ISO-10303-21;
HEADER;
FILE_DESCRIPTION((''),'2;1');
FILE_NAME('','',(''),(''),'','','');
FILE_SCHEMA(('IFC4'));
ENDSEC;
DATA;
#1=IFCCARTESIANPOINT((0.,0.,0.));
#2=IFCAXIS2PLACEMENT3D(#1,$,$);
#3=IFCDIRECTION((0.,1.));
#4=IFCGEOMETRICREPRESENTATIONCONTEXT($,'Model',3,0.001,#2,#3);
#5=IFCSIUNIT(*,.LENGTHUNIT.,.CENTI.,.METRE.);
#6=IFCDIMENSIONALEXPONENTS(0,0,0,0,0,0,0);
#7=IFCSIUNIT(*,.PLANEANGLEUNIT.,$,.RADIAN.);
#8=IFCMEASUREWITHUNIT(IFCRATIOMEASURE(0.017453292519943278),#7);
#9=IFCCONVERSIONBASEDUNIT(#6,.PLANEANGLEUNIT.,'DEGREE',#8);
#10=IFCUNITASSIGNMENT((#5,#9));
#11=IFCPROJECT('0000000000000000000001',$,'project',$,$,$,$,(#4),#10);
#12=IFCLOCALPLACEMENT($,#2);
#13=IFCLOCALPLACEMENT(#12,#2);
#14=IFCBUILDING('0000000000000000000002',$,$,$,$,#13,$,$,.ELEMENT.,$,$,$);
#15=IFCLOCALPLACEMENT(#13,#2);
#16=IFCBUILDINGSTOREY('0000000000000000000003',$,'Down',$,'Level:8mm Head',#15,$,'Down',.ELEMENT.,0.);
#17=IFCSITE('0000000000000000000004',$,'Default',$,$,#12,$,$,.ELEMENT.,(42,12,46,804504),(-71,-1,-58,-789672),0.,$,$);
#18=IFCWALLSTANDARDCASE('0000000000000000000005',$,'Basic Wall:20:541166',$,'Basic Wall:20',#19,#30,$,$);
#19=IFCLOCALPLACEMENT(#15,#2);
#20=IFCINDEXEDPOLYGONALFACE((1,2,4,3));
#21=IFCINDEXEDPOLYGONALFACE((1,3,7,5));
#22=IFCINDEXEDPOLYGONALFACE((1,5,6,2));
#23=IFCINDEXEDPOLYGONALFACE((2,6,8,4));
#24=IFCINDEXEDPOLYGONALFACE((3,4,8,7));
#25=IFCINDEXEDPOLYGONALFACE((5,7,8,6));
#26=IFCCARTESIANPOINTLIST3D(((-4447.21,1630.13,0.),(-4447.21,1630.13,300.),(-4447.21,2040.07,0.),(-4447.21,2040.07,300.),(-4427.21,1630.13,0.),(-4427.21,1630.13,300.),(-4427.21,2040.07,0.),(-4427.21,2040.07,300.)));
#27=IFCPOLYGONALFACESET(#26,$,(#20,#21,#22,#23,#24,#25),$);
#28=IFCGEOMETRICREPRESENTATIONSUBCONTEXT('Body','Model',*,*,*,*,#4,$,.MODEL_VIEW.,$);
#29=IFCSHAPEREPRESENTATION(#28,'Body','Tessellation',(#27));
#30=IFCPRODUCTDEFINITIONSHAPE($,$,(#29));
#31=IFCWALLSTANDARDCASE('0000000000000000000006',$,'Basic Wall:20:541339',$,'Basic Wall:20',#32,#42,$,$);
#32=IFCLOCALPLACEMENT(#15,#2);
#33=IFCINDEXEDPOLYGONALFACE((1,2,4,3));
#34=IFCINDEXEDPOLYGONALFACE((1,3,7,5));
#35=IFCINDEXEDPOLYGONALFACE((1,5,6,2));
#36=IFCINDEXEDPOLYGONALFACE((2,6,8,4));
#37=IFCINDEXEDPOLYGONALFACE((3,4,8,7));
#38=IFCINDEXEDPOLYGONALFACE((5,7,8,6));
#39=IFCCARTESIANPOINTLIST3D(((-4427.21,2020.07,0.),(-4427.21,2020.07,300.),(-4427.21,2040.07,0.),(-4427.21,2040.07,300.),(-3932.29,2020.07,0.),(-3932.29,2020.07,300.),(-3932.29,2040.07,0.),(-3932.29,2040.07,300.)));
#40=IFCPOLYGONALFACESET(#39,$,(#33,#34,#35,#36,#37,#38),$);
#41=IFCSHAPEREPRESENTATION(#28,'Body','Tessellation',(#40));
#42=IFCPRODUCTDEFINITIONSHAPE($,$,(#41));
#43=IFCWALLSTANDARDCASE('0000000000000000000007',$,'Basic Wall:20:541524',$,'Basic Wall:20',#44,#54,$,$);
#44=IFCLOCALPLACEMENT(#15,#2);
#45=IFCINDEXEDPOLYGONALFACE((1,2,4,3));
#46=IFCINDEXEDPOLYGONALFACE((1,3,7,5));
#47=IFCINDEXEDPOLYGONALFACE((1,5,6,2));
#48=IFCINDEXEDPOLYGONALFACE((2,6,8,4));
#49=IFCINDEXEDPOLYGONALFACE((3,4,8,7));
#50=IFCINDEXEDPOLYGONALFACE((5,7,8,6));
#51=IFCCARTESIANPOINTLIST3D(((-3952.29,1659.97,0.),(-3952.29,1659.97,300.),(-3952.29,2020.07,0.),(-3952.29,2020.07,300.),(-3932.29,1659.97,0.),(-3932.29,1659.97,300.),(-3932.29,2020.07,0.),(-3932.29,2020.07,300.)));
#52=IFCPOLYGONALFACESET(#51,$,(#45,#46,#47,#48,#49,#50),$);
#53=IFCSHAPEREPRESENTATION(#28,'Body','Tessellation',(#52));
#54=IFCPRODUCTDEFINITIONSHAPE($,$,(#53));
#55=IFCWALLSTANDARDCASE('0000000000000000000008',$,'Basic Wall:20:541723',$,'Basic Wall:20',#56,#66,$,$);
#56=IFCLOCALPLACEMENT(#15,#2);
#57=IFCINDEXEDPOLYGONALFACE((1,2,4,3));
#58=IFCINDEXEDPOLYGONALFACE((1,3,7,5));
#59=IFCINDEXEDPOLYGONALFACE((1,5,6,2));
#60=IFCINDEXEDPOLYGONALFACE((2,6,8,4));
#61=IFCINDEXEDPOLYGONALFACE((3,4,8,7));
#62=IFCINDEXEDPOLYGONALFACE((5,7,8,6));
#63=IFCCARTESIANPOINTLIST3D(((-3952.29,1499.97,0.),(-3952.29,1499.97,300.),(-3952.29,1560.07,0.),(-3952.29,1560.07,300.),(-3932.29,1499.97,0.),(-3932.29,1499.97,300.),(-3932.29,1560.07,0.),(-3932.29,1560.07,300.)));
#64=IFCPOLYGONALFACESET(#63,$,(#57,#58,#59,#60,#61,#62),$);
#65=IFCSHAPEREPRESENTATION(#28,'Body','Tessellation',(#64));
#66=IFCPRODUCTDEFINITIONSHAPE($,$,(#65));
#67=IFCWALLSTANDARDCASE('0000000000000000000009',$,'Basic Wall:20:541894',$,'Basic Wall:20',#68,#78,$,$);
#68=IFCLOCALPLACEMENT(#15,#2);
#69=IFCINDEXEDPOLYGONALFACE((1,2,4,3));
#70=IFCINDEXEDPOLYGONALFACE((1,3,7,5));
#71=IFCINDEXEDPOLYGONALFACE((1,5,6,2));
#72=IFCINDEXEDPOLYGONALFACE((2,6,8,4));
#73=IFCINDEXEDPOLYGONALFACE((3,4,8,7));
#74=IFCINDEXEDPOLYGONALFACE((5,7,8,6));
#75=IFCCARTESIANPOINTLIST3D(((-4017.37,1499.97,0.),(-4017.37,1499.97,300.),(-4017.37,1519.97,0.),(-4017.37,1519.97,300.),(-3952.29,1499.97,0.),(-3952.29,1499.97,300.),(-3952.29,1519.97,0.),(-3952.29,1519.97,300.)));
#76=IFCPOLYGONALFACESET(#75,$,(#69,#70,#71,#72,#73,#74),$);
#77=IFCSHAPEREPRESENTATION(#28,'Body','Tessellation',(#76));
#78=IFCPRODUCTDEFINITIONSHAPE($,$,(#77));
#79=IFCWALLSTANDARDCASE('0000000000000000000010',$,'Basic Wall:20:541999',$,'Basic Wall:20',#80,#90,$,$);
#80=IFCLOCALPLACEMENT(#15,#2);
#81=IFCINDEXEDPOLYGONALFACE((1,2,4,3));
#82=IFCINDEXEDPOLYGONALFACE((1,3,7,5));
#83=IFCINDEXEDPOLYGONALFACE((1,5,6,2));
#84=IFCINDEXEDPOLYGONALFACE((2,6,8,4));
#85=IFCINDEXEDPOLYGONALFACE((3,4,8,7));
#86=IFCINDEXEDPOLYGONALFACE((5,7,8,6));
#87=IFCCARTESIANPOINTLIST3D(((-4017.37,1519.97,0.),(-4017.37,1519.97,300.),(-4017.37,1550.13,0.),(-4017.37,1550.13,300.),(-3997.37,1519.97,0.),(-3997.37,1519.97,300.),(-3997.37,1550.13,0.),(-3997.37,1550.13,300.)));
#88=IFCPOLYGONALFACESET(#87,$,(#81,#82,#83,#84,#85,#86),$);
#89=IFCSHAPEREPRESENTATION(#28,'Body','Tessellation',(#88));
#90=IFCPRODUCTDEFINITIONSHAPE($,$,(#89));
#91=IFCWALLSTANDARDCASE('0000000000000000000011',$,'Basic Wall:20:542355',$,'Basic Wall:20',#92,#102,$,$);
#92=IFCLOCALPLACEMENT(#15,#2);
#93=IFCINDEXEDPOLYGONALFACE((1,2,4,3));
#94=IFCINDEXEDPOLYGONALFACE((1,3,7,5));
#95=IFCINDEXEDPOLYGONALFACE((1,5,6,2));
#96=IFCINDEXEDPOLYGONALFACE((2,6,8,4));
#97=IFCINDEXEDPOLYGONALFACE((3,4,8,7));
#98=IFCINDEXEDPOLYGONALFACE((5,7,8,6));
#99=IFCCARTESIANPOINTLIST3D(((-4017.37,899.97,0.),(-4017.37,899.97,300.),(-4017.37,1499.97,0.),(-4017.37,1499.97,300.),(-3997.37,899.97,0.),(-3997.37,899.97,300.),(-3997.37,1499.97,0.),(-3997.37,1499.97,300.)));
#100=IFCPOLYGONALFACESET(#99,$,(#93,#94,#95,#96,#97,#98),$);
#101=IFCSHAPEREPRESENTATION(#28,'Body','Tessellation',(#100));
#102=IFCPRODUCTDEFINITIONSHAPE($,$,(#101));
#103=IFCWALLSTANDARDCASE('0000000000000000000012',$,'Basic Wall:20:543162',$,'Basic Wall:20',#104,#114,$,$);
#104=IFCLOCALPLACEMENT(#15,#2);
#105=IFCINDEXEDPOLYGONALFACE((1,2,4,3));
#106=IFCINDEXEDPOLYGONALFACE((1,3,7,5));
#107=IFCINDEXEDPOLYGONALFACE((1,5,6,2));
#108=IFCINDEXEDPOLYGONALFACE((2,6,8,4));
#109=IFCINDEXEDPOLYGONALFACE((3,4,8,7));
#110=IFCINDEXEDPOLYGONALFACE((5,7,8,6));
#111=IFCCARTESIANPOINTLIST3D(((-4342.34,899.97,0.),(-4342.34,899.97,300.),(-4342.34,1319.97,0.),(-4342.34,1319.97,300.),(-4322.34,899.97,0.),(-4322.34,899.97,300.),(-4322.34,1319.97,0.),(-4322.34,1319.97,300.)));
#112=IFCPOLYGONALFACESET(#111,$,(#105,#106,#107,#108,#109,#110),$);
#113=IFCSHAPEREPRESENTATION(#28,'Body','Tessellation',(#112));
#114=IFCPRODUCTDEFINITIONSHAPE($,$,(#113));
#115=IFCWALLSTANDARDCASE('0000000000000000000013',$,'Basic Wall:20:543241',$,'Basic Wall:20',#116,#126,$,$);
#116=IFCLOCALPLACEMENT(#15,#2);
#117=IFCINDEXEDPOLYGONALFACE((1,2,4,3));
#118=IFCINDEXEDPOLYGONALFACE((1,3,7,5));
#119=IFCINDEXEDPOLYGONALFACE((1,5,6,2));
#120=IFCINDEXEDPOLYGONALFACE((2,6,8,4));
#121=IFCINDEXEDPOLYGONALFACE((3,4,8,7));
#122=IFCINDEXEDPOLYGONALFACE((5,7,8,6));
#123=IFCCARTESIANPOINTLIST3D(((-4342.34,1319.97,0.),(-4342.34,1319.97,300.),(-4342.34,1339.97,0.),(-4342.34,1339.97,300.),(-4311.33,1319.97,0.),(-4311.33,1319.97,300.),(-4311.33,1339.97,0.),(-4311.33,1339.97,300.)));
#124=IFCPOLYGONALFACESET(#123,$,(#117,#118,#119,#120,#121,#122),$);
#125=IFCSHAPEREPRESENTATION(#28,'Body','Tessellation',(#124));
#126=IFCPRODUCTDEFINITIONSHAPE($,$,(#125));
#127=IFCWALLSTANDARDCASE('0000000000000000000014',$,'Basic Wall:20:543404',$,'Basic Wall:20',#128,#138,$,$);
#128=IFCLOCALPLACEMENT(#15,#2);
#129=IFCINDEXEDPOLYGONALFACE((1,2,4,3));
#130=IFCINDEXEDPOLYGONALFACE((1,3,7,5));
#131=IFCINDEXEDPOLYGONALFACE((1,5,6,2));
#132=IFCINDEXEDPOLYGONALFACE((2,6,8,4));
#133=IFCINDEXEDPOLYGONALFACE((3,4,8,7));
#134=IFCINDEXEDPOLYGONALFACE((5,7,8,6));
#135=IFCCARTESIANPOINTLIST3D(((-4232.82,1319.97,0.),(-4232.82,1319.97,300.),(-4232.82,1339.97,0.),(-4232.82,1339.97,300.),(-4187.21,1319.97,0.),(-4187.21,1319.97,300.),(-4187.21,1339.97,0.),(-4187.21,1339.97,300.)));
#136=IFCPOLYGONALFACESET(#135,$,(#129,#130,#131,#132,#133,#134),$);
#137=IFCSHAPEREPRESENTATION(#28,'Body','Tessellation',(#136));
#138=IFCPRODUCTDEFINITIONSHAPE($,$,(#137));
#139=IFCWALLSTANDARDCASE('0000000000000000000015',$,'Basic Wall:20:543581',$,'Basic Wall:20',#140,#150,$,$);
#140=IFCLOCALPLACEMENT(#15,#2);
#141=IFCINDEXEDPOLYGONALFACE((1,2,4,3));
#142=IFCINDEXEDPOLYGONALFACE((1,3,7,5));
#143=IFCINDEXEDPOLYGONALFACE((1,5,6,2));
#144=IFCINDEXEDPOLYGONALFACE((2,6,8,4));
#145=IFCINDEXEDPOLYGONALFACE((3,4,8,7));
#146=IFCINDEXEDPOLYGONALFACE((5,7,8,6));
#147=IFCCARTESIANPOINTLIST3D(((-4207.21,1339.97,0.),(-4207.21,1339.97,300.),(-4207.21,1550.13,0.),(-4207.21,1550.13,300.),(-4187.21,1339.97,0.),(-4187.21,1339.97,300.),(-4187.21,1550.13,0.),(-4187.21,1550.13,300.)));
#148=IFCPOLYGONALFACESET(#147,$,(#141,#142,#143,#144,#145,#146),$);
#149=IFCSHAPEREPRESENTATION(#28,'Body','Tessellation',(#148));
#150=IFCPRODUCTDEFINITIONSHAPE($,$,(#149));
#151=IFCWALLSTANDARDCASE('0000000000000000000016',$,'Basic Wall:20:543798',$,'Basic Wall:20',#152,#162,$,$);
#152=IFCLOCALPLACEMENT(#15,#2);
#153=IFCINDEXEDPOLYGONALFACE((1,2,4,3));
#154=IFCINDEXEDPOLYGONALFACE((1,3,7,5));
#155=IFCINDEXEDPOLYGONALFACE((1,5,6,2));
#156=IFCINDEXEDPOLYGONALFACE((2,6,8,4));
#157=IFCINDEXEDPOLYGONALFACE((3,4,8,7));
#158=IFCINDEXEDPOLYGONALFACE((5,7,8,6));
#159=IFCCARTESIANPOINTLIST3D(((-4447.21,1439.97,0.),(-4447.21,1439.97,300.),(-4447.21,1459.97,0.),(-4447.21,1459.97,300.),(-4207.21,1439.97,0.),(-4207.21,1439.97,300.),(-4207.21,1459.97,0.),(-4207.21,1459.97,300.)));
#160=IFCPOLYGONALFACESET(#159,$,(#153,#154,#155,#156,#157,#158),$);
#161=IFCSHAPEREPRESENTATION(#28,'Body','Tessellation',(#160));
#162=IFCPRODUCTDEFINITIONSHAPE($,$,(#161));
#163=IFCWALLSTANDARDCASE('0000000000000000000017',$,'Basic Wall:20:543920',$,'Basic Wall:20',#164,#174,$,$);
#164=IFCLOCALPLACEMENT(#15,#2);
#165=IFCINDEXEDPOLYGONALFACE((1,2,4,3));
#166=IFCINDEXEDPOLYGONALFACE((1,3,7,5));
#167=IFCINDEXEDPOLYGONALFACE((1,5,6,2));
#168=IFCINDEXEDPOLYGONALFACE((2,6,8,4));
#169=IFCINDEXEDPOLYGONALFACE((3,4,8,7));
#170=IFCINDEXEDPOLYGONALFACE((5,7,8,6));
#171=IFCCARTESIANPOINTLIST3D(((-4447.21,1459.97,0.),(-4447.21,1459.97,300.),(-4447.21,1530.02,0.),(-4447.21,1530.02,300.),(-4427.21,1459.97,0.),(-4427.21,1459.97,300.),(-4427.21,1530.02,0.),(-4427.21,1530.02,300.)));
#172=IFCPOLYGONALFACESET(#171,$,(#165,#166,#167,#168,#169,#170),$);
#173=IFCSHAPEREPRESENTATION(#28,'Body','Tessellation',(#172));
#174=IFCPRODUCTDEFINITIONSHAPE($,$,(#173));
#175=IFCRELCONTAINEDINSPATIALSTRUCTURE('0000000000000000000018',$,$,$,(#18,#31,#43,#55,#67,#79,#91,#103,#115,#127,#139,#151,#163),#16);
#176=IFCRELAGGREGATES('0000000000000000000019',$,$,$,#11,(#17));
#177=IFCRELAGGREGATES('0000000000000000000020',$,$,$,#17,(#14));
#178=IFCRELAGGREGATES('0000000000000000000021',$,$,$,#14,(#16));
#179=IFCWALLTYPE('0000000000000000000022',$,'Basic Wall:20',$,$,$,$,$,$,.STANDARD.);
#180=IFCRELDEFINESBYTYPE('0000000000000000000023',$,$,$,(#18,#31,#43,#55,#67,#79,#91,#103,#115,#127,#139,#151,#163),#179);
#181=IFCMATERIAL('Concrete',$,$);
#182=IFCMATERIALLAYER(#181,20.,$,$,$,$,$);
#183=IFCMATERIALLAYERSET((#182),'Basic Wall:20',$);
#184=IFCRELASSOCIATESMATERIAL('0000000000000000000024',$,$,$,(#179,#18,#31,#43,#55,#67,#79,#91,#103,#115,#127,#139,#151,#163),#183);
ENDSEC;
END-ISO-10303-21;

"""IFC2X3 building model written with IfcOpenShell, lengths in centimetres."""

from ifc_helpers import new_model, entity, si_unit, converted_unit, direction, frame, frame_2d, origin, place, context, subcontext, project, spatial, rectangle, extrude, material, layer, layer_set, layer_usage, type_object, element, save


model = new_model("IFC2X3")

# Units and contexts
model_context = context("Model", 3, precision=0.001, world=origin(), true_north=direction((0.0, 1.0)))
body_context = subcontext(model_context, "Body", "Model", "MODEL_VIEW")
ifc_project = project(units=[si_unit("LENGTHUNIT", "METRE", prefix="CENTI"), converted_unit("PLANEANGLEUNIT", "DEGREE", entity("IfcRatioMeasure", 0.017453292519943278), si_unit("PLANEANGLEUNIT", "RADIAN"), dimensions=[0, 0, 0, 0, 0, 0, 0])], contexts=[model_context])

# Site, building, storey
site_placement = place(None, origin())
site = spatial("IfcSite", under=ifc_project, at=site_placement, Name="Default", CompositionType="ELEMENT", RefLatitude=(42, 12, 46, 804504), RefLongitude=(-71, -1, -58, -789672), RefElevation=0.0)
building_placement = place(site_placement, origin())
building = spatial("IfcBuilding", under=site, at=building_placement, CompositionType="ELEMENT")
storey_placement = place(building_placement, origin())
storey = spatial("IfcBuildingStorey", under=building, at=storey_placement, Name="Down", ObjectType="Level:8mm Head", LongName="Down", CompositionType="ELEMENT", Elevation=0.0)

# Shared definitions
ifc_material = material(Name="Concrete")

# Walls
ifc_layer_1 = layer(ifc_material, 20.0)
ifc_layer_set_1 = layer_set([ifc_layer_1], Name="Basic Wall:20")
wall_type_1 = type_object("IfcWallType", Name="Basic Wall:20", PredefinedType="STANDARD", material=ifc_layer_set_1)
ifc_layer_usage_1 = layer_usage(ifc_layer_set_1, "AXIS2", "NEGATIVE", 10.0)
wall_1_placement = place(storey_placement, frame((-4437.21, 1630.13, 0.0), z_axis=(0.0, 0.0, 1.0), x_axis=(0.0, 1.0, 0.0)))
element("IfcWallStandardCase", 1, at=wall_1_placement, inside=storey, type_object=wall_type_1, material=ifc_layer_usage_1, Name="Basic Wall:20:541166", ObjectType="Basic Wall:20", context=body_context, shape_type="SweptSolid", body=[
    extrude(rectangle(XDim=409.95, YDim=20.0, at=frame_2d((204.97, 0.0), x_axis=(-1.0, 0.0))), origin(), (0.0, 0.0, 1.0), 300.0),
])
ifc_layer_usage_2 = layer_usage(ifc_layer_set_1, "AXIS2", "NEGATIVE", 10.0)
wall_2_placement = place(storey_placement, frame((-4427.21, 2030.07, 0.0)))
element("IfcWallStandardCase", 2, at=wall_2_placement, inside=storey, type_object=wall_type_1, material=ifc_layer_usage_2, Name="Basic Wall:20:541339", ObjectType="Basic Wall:20", context=body_context, shape_type="SweptSolid", body=[
    extrude(rectangle(XDim=494.92, YDim=20.0, at=frame_2d((247.46, 0.0), x_axis=(-1.0, 0.0))), origin(), (0.0, 0.0, 1.0), 300.0),
])
ifc_layer_usage_3 = layer_usage(ifc_layer_set_1, "AXIS2", "NEGATIVE", 10.0)
wall_3_placement = place(storey_placement, frame((-3942.29, 2020.07, 0.0), z_axis=(0.0, 0.0, 1.0), x_axis=(0.0, -1.0, 0.0)))
element("IfcWallStandardCase", 3, at=wall_3_placement, inside=storey, type_object=wall_type_1, material=ifc_layer_usage_3, Name="Basic Wall:20:541524", ObjectType="Basic Wall:20", context=body_context, shape_type="SweptSolid", body=[
    extrude(rectangle(XDim=360.11, YDim=20.0, at=frame_2d((180.05, 0.0), x_axis=(-1.0, 0.0))), origin(), (0.0, 0.0, 1.0), 300.0),
])
ifc_layer_usage_4 = layer_usage(ifc_layer_set_1, "AXIS2", "NEGATIVE", 10.0)
wall_4_placement = place(storey_placement, frame((-3942.29, 1560.07, 0.0), z_axis=(0.0, 0.0, 1.0), x_axis=(0.0, -1.0, 0.0)))
element("IfcWallStandardCase", 4, at=wall_4_placement, inside=storey, type_object=wall_type_1, material=ifc_layer_usage_4, Name="Basic Wall:20:541723", ObjectType="Basic Wall:20", context=body_context, shape_type="SweptSolid", body=[
    extrude(rectangle(XDim=60.11, YDim=20.0, at=frame_2d((30.05, 0.0), x_axis=(-1.0, 0.0))), origin(), (0.0, 0.0, 1.0), 300.0),
])
ifc_layer_usage_5 = layer_usage(ifc_layer_set_1, "AXIS2", "NEGATIVE", 10.0)
wall_5_placement = place(storey_placement, frame((-3952.29, 1509.97, 0.0), z_axis=(0.0, 0.0, 1.0), x_axis=(-1.0, 0.0, 0.0)))
element("IfcWallStandardCase", 5, at=wall_5_placement, inside=storey, type_object=wall_type_1, material=ifc_layer_usage_5, Name="Basic Wall:20:541894", ObjectType="Basic Wall:20", context=body_context, shape_type="SweptSolid", body=[
    extrude(rectangle(XDim=65.08, YDim=20.0, at=frame_2d((32.54, 0.0), x_axis=(-1.0, 0.0))), origin(), (0.0, 0.0, 1.0), 300.0),
])
ifc_layer_usage_6 = layer_usage(ifc_layer_set_1, "AXIS2", "NEGATIVE", 10.0)
wall_6_placement = place(storey_placement, frame((-4007.37, 1519.97, 0.0), z_axis=(0.0, 0.0, 1.0), x_axis=(0.0, 1.0, 0.0)))
element("IfcWallStandardCase", 6, at=wall_6_placement, inside=storey, type_object=wall_type_1, material=ifc_layer_usage_6, Name="Basic Wall:20:541999", ObjectType="Basic Wall:20", context=body_context, shape_type="SweptSolid", body=[
    extrude(rectangle(XDim=30.16, YDim=20.0, at=frame_2d((15.08, 0.0), x_axis=(-1.0, 0.0))), origin(), (0.0, 0.0, 1.0), 300.0),
])
ifc_layer_usage_7 = layer_usage(ifc_layer_set_1, "AXIS2", "POSITIVE", -10.0)
wall_7_placement = place(storey_placement, frame((-4007.37, 1499.97, 0.0), z_axis=(0.0, 0.0, 1.0), x_axis=(0.0, -1.0, 0.0)))
element("IfcWallStandardCase", 7, at=wall_7_placement, inside=storey, type_object=wall_type_1, material=ifc_layer_usage_7, Name="Basic Wall:20:542355", ObjectType="Basic Wall:20", context=body_context, shape_type="SweptSolid", body=[
    extrude(rectangle(XDim=600.0, YDim=20.0, at=frame_2d((300.0, 0.0), x_axis=(-1.0, 0.0))), origin(), (0.0, 0.0, 1.0), 300.0),
])
ifc_layer_usage_8 = layer_usage(ifc_layer_set_1, "AXIS2", "POSITIVE", -10.0)
wall_8_placement = place(storey_placement, frame((-4332.34, 899.97, 0.0), z_axis=(0.0, 0.0, 1.0), x_axis=(0.0, 1.0, 0.0)))
element("IfcWallStandardCase", 8, at=wall_8_placement, inside=storey, type_object=wall_type_1, material=ifc_layer_usage_8, Name="Basic Wall:20:543162", ObjectType="Basic Wall:20", context=body_context, shape_type="SweptSolid", body=[
    extrude(rectangle(XDim=420.0, YDim=20.0, at=frame_2d((210.0, 0.0), x_axis=(-1.0, 0.0))), origin(), (0.0, 0.0, 1.0), 300.0),
])
ifc_layer_usage_9 = layer_usage(ifc_layer_set_1, "AXIS2", "NEGATIVE", 10.0)
wall_9_placement = place(storey_placement, frame((-4342.34, 1329.97, 0.0)))
element("IfcWallStandardCase", 9, at=wall_9_placement, inside=storey, type_object=wall_type_1, material=ifc_layer_usage_9, Name="Basic Wall:20:543241", ObjectType="Basic Wall:20", context=body_context, shape_type="SweptSolid", body=[
    extrude(rectangle(XDim=31.01, YDim=20.0, at=frame_2d((15.5, 0.0), x_axis=(-1.0, 0.0))), origin(), (0.0, 0.0, 1.0), 300.0),
])
ifc_layer_usage_10 = layer_usage(ifc_layer_set_1, "AXIS2", "NEGATIVE", 10.0)
wall_10_placement = place(storey_placement, frame((-4232.82, 1329.97, 0.0)))
element("IfcWallStandardCase", 10, at=wall_10_placement, inside=storey, type_object=wall_type_1, material=ifc_layer_usage_10, Name="Basic Wall:20:543404", ObjectType="Basic Wall:20", context=body_context, shape_type="SweptSolid", body=[
    extrude(rectangle(XDim=45.61, YDim=20.0, at=frame_2d((22.8, 0.0), x_axis=(-1.0, 0.0))), origin(), (0.0, 0.0, 1.0), 300.0),
])
ifc_layer_usage_11 = layer_usage(ifc_layer_set_1, "AXIS2", "NEGATIVE", 10.0)
wall_11_placement = place(storey_placement, frame((-4197.21, 1339.97, 0.0), z_axis=(0.0, 0.0, 1.0), x_axis=(0.0, 1.0, 0.0)))
element("IfcWallStandardCase", 11, at=wall_11_placement, inside=storey, type_object=wall_type_1, material=ifc_layer_usage_11, Name="Basic Wall:20:543581", ObjectType="Basic Wall:20", context=body_context, shape_type="SweptSolid", body=[
    extrude(rectangle(XDim=210.16, YDim=20.0, at=frame_2d((105.08, 0.0), x_axis=(-1.0, 0.0))), origin(), (0.0, 0.0, 1.0), 300.0),
])
ifc_layer_usage_12 = layer_usage(ifc_layer_set_1, "AXIS2", "POSITIVE", -10.0)
wall_12_placement = place(storey_placement, frame((-4207.21, 1449.97, 0.0), z_axis=(0.0, 0.0, 1.0), x_axis=(-1.0, 0.0, 0.0)))
element("IfcWallStandardCase", 12, at=wall_12_placement, inside=storey, type_object=wall_type_1, material=ifc_layer_usage_12, Name="Basic Wall:20:543798", ObjectType="Basic Wall:20", context=body_context, shape_type="SweptSolid", body=[
    extrude(rectangle(XDim=240.0, YDim=20.0, at=frame_2d((120.0, 0.0), x_axis=(-1.0, 0.0))), origin(), (0.0, 0.0, 1.0), 300.0),
])
ifc_layer_usage_13 = layer_usage(ifc_layer_set_1, "AXIS2", "NEGATIVE", 10.0)
wall_13_placement = place(storey_placement, frame((-4437.21, 1459.97, 0.0), z_axis=(0.0, 0.0, 1.0), x_axis=(0.0, 1.0, 0.0)))
element("IfcWallStandardCase", 13, at=wall_13_placement, inside=storey, type_object=wall_type_1, material=ifc_layer_usage_13, Name="Basic Wall:20:543920", ObjectType="Basic Wall:20", context=body_context, shape_type="SweptSolid", body=[
    extrude(rectangle(XDim=70.05, YDim=20.0, at=frame_2d((35.03, 0.0), x_axis=(-1.0, 0.0))), origin(), (0.0, 0.0, 1.0), 300.0),
])

save(model, "model.ifc")
